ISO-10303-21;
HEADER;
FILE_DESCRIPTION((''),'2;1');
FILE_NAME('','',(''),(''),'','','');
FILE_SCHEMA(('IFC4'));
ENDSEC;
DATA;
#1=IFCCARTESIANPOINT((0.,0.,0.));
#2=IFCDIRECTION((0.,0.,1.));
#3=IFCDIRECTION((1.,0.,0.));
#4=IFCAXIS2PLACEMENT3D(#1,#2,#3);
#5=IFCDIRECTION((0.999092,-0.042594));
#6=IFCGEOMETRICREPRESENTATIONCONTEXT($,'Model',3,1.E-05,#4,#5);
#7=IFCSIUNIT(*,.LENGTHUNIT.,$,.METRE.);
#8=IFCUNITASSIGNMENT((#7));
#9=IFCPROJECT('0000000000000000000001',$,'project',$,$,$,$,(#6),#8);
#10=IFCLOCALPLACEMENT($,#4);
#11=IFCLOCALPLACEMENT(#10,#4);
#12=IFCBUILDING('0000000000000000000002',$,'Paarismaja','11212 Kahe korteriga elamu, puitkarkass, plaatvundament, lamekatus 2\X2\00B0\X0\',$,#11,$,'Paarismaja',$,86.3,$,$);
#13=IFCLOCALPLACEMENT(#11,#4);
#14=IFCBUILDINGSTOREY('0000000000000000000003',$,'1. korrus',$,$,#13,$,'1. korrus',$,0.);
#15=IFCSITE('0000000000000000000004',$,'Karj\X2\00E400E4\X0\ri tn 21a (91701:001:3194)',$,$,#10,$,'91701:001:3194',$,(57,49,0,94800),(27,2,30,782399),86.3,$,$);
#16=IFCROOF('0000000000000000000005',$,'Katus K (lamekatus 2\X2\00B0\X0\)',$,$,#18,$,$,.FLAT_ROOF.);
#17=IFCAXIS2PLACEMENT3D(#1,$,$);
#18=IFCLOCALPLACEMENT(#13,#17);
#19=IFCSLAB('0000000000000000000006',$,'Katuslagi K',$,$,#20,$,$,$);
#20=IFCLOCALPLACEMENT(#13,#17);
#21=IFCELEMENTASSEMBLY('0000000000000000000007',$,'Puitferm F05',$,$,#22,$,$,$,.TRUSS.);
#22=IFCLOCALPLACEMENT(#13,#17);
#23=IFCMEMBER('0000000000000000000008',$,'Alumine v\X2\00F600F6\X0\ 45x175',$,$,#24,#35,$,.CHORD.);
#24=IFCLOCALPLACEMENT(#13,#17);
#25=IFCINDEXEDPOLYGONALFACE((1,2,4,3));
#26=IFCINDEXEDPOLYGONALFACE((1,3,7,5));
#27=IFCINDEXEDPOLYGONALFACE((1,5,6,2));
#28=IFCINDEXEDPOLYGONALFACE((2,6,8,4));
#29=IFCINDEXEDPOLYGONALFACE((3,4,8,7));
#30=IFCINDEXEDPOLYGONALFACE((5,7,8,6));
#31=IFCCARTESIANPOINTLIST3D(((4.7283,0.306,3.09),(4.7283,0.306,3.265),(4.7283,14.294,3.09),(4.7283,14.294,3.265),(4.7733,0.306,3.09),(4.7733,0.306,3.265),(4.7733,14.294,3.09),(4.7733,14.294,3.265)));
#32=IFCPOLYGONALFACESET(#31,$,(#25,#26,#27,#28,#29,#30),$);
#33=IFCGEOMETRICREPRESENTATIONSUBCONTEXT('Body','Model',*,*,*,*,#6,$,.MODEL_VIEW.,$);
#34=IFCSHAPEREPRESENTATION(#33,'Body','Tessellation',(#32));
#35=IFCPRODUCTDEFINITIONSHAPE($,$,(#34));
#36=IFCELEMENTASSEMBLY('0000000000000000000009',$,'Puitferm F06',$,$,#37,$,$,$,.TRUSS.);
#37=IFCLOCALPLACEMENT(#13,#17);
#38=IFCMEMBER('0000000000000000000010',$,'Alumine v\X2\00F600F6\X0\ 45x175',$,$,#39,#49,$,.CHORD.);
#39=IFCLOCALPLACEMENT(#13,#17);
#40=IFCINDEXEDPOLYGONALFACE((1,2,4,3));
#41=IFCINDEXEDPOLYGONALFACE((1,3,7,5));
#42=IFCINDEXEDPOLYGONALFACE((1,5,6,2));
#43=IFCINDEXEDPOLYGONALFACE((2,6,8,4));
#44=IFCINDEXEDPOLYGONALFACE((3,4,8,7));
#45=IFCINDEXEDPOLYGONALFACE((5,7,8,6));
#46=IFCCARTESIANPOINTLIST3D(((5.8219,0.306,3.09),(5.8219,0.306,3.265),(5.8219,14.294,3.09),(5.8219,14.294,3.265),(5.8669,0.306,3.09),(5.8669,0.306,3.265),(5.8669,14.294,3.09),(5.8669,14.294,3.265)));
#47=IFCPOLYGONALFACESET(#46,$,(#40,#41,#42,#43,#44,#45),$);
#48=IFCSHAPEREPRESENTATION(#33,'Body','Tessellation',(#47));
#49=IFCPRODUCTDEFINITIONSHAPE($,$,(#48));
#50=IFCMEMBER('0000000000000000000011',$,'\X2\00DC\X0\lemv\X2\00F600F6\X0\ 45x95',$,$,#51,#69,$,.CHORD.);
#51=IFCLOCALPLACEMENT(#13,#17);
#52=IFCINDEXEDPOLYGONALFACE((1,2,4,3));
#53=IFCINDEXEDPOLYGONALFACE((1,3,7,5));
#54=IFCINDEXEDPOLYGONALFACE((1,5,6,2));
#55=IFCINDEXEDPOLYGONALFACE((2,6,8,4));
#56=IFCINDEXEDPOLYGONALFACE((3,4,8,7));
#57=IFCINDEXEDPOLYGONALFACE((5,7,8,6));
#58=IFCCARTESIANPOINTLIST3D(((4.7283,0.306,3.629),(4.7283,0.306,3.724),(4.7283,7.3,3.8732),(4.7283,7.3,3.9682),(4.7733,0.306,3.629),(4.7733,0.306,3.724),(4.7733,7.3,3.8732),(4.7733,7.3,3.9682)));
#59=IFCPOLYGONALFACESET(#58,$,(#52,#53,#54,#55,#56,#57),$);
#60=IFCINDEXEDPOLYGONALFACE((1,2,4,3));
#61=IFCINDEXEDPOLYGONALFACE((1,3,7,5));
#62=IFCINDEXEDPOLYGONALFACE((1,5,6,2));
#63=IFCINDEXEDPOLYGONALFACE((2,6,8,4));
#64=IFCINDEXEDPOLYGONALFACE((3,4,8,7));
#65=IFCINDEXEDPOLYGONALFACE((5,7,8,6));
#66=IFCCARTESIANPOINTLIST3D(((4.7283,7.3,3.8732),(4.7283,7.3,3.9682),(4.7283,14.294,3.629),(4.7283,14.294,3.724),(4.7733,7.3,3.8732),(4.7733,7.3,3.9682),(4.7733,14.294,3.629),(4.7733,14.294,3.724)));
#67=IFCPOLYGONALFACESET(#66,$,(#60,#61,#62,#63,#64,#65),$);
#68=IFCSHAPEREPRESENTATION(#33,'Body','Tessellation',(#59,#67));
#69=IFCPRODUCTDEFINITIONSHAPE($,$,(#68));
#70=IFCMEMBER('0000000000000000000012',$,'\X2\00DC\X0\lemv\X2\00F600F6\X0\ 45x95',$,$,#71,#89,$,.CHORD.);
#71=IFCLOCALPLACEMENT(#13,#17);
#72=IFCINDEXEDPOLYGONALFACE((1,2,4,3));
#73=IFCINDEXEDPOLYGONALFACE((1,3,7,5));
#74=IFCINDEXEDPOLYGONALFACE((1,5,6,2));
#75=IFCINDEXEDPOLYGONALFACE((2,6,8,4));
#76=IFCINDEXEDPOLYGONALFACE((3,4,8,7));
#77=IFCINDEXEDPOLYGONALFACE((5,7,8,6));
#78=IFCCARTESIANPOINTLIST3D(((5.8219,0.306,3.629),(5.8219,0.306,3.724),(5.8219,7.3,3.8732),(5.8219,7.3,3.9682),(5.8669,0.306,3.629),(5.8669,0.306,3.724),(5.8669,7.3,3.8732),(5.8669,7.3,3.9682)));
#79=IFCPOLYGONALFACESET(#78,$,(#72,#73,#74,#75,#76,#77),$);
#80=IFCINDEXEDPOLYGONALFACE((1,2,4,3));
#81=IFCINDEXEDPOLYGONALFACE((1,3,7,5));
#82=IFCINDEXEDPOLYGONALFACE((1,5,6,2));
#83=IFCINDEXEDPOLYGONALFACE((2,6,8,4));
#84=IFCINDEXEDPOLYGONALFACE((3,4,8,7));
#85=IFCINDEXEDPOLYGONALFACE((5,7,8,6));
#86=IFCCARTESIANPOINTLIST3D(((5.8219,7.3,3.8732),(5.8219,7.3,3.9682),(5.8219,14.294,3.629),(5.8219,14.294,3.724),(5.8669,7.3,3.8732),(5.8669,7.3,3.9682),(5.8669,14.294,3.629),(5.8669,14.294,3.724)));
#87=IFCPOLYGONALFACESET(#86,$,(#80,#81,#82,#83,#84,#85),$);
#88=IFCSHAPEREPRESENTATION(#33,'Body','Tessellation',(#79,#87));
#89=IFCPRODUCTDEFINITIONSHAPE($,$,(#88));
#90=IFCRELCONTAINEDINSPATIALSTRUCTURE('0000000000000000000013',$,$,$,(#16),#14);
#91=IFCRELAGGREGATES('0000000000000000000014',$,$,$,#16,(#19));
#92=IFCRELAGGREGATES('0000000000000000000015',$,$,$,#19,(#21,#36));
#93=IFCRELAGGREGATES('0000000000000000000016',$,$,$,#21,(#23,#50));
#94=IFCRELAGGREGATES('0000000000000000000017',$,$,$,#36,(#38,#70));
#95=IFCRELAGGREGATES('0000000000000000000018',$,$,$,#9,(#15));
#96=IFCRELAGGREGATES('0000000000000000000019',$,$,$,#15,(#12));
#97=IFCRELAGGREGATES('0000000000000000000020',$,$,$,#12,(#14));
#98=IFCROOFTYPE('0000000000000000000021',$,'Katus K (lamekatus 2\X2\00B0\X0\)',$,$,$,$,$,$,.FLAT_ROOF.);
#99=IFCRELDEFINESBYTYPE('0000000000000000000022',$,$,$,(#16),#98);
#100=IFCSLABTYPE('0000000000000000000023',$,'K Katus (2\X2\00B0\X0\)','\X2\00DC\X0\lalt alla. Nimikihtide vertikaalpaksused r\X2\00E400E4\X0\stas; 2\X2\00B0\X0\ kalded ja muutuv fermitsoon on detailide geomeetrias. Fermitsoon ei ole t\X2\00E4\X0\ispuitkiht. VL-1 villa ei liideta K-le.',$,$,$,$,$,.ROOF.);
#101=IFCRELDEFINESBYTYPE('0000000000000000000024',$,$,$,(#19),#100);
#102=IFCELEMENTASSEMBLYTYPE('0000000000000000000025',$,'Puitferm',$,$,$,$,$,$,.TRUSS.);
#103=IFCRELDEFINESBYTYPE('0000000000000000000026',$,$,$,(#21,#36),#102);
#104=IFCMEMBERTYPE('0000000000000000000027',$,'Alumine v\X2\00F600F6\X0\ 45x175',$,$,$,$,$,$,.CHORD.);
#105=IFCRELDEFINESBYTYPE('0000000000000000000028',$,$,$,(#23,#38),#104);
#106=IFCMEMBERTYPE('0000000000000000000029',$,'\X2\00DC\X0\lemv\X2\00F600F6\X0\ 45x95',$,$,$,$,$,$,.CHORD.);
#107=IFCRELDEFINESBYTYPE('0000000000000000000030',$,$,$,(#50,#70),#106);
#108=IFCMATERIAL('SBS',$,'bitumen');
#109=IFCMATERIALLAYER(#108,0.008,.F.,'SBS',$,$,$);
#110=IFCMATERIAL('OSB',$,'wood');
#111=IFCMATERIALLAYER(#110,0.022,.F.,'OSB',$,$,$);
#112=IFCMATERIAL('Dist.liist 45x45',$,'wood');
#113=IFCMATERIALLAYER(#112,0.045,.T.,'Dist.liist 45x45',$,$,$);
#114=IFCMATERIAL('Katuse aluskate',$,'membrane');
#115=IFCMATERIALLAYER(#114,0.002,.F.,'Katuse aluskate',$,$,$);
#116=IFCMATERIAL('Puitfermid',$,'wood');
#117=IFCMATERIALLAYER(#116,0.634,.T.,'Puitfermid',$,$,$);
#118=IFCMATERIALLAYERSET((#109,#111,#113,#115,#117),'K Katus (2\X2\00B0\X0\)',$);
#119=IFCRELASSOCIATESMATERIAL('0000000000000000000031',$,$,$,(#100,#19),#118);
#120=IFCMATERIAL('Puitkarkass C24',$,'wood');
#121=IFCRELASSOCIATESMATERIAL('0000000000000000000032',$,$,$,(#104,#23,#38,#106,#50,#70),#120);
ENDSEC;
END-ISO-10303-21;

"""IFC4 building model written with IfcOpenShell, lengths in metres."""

from ifc_helpers import new_model, si_unit, direction, frame, origin_with_axes, place, context, subcontext, project, spatial, indexed_curve, outline, extrude, material, layer, layer_set, layer_usage, type_object, element, aggregate, save


model = new_model("IFC4")

# Units and contexts
model_context = context("Model", 3, precision=1e-05, world=origin_with_axes(), true_north=direction((0.999092, -0.042594)))
body_context = subcontext(model_context, "Body", "Model", "MODEL_VIEW")
ifc_project = project(units=[si_unit("LENGTHUNIT", "METRE")], contexts=[model_context])

# Site, building, storey
site_placement = place(None, origin_with_axes())
site = spatial("IfcSite", under=ifc_project, at=site_placement, Name="Karjääri tn 21a (91701:001:3194)", LongName="91701:001:3194", RefLatitude=(57, 49, 0, 94800), RefLongitude=(27, 2, 30, 782399), RefElevation=86.3)
building_placement = place(site_placement, origin_with_axes())
building = spatial("IfcBuilding", under=site, at=building_placement, Name="Paarismaja", Description="11212 Kahe korteriga elamu, puitkarkass, plaatvundament, lamekatus 2°", LongName="Paarismaja", ElevationOfRefHeight=86.3)
storey_placement = place(building_placement, origin_with_axes())
storey = spatial("IfcBuildingStorey", under=building, at=storey_placement, Name="1. korrus", LongName="1. korrus", Elevation=0.0)

# Shared definitions
ifc_material_1 = material(Name="Puitkarkass C24", Category="wood")

# Roof, slab, element assemblies, members
roof_type = type_object("IfcRoofType", Name="Katus K (lamekatus 2°)", PredefinedType="FLAT_ROOF")
roof_placement = place(storey_placement, origin_with_axes())
roof = element("IfcRoof", 1, at=roof_placement, inside=storey, type_object=roof_type, Name="Katus K (lamekatus 2°)", PredefinedType="FLAT_ROOF")
ifc_material_2 = material(Name="SBS", Category="bitumen")
ifc_layer_1 = layer(ifc_material_2, 0.008, ventilated=False, Name="SBS")
ifc_material_3 = material(Name="OSB", Category="wood")
ifc_layer_2 = layer(ifc_material_3, 0.022, ventilated=False, Name="OSB")
ifc_material_4 = material(Name="Dist.liist 45x45", Category="wood")
ifc_layer_3 = layer(ifc_material_4, 0.045, ventilated=True, Name="Dist.liist 45x45")
ifc_material_5 = material(Name="Katuse aluskate", Category="membrane")
ifc_layer_4 = layer(ifc_material_5, 0.002, ventilated=False, Name="Katuse aluskate")
ifc_material_6 = material(Name="Puitfermid", Category="wood")
ifc_layer_5 = layer(ifc_material_6, 0.634, ventilated=True, Name="Puitfermid")
ifc_layer_set_1 = layer_set([ifc_layer_1, ifc_layer_2, ifc_layer_3, ifc_layer_4, ifc_layer_5], Name="K Katus (2°)")
ifc_layer_usage_1 = layer_usage(ifc_layer_set_1, "AXIS3", "NEGATIVE", 3.801)
slab_type = type_object("IfcSlabType", Name="K Katus (2°)", Description="Ülalt alla. Nimikihtide vertikaalpaksused räästas; 2° kalded ja muutuv fermitsoon on detailide geomeetrias. Fermitsoon ei ole täispuitkiht. VL-1 villa ei liideta K-le.", PredefinedType="ROOF", material=ifc_layer_set_1)
slab_placement = place(roof_placement, origin_with_axes())
slab = element("IfcSlab", 2, at=slab_placement, type_object=slab_type, material=ifc_layer_usage_1, Name="Katuslagi K")
aggregate(roof, [slab])
element_assembly_type = type_object("IfcElementAssemblyType", Name="Puitferm", PredefinedType="TRUSS")
assembly_1_placement = place(slab_placement, frame((4.7283, 0.0, 0.0), z_axis=(0.0, 0.0, 1.0), x_axis=(1.0, 0.0, 0.0)))
assembly_1 = element("IfcElementAssembly", 3, at=assembly_1_placement, type_object=element_assembly_type, Name="Puitferm F05", PredefinedType="TRUSS")
member_type_1 = type_object("IfcMemberType", Name="Alumine vöö 45x175", PredefinedType="CHORD", material=ifc_material_1)
member_1_placement = place(assembly_1_placement, origin_with_axes())
member_1 = element("IfcMember", 4, at=member_1_placement, type_object=member_type_1, material=ifc_material_1, Name="Alumine vöö 45x175", PredefinedType="CHORD", context=body_context, shape_type="SweptSolid", body=[
    extrude(outline(indexed_curve([(0.306, 3.09), (14.294, 3.09), (14.294, 3.265), (0.306, 3.265), (0.306, 3.09)], self_intersect=False)), frame((0.0, 0.0, 0.0), z_axis=(1.0, 0.0, 0.0), x_axis=(0.0, 1.0, 0.0)), (0.0, 0.0, 1.0), 0.045),
])
assembly_2_placement = place(slab_placement, frame((5.8219, 0.0, 0.0), z_axis=(0.0, 0.0, 1.0), x_axis=(1.0, 0.0, 0.0)))
assembly_2 = element("IfcElementAssembly", 5, at=assembly_2_placement, type_object=element_assembly_type, Name="Puitferm F06", PredefinedType="TRUSS")
aggregate(slab, [assembly_1, assembly_2])
member_2_placement = place(assembly_2_placement, origin_with_axes())
member_2 = element("IfcMember", 6, at=member_2_placement, type_object=member_type_1, material=ifc_material_1, Name="Alumine vöö 45x175", PredefinedType="CHORD", context=body_context, shape_type="SweptSolid", body=[
    extrude(outline(indexed_curve([(0.306, 3.09), (14.294, 3.09), (14.294, 3.265), (0.306, 3.265), (0.306, 3.09)], self_intersect=False)), frame((0.0, 0.0, 0.0), z_axis=(1.0, 0.0, 0.0), x_axis=(0.0, 1.0, 0.0)), (0.0, 0.0, 1.0), 0.045),
])
member_type_2 = type_object("IfcMemberType", Name="Ülemvöö 45x95", PredefinedType="CHORD", material=ifc_material_1)
member_3_placement = place(assembly_1_placement, origin_with_axes())
member_3 = element("IfcMember", 7, at=member_3_placement, type_object=member_type_2, material=ifc_material_1, Name="Ülemvöö 45x95", PredefinedType="CHORD", context=body_context, shape_type="SweptSolid", body=[
    extrude(outline(indexed_curve([(0.306, 3.629), (7.3, 3.8732), (7.3, 3.9682), (0.306, 3.724), (0.306, 3.629)], self_intersect=False)), frame((0.0, 0.0, 0.0), z_axis=(1.0, 0.0, 0.0), x_axis=(0.0, 1.0, 0.0)), (0.0, 0.0, 1.0), 0.045),
    extrude(outline(indexed_curve([(7.3, 3.8732), (14.294, 3.629), (14.294, 3.724), (7.3, 3.9682), (7.3, 3.8732)], self_intersect=False)), frame((0.0, 0.0, 0.0), z_axis=(1.0, 0.0, 0.0), x_axis=(0.0, 1.0, 0.0)), (0.0, 0.0, 1.0), 0.045),
])
member_4_placement = place(assembly_2_placement, origin_with_axes())
member_4 = element("IfcMember", 8, at=member_4_placement, type_object=member_type_2, material=ifc_material_1, Name="Ülemvöö 45x95", PredefinedType="CHORD", context=body_context, shape_type="SweptSolid", body=[
    extrude(outline(indexed_curve([(0.306, 3.629), (7.3, 3.8732), (7.3, 3.9682), (0.306, 3.724), (0.306, 3.629)], self_intersect=False)), frame((0.0, 0.0, 0.0), z_axis=(1.0, 0.0, 0.0), x_axis=(0.0, 1.0, 0.0)), (0.0, 0.0, 1.0), 0.045),
    extrude(outline(indexed_curve([(7.3, 3.8732), (14.294, 3.629), (14.294, 3.724), (7.3, 3.9682), (7.3, 3.8732)], self_intersect=False)), frame((0.0, 0.0, 0.0), z_axis=(1.0, 0.0, 0.0), x_axis=(0.0, 1.0, 0.0)), (0.0, 0.0, 1.0), 0.045),
])
aggregate(assembly_1, [member_1, member_3])
aggregate(assembly_2, [member_2, member_4])

save(model, "model.ifc")
